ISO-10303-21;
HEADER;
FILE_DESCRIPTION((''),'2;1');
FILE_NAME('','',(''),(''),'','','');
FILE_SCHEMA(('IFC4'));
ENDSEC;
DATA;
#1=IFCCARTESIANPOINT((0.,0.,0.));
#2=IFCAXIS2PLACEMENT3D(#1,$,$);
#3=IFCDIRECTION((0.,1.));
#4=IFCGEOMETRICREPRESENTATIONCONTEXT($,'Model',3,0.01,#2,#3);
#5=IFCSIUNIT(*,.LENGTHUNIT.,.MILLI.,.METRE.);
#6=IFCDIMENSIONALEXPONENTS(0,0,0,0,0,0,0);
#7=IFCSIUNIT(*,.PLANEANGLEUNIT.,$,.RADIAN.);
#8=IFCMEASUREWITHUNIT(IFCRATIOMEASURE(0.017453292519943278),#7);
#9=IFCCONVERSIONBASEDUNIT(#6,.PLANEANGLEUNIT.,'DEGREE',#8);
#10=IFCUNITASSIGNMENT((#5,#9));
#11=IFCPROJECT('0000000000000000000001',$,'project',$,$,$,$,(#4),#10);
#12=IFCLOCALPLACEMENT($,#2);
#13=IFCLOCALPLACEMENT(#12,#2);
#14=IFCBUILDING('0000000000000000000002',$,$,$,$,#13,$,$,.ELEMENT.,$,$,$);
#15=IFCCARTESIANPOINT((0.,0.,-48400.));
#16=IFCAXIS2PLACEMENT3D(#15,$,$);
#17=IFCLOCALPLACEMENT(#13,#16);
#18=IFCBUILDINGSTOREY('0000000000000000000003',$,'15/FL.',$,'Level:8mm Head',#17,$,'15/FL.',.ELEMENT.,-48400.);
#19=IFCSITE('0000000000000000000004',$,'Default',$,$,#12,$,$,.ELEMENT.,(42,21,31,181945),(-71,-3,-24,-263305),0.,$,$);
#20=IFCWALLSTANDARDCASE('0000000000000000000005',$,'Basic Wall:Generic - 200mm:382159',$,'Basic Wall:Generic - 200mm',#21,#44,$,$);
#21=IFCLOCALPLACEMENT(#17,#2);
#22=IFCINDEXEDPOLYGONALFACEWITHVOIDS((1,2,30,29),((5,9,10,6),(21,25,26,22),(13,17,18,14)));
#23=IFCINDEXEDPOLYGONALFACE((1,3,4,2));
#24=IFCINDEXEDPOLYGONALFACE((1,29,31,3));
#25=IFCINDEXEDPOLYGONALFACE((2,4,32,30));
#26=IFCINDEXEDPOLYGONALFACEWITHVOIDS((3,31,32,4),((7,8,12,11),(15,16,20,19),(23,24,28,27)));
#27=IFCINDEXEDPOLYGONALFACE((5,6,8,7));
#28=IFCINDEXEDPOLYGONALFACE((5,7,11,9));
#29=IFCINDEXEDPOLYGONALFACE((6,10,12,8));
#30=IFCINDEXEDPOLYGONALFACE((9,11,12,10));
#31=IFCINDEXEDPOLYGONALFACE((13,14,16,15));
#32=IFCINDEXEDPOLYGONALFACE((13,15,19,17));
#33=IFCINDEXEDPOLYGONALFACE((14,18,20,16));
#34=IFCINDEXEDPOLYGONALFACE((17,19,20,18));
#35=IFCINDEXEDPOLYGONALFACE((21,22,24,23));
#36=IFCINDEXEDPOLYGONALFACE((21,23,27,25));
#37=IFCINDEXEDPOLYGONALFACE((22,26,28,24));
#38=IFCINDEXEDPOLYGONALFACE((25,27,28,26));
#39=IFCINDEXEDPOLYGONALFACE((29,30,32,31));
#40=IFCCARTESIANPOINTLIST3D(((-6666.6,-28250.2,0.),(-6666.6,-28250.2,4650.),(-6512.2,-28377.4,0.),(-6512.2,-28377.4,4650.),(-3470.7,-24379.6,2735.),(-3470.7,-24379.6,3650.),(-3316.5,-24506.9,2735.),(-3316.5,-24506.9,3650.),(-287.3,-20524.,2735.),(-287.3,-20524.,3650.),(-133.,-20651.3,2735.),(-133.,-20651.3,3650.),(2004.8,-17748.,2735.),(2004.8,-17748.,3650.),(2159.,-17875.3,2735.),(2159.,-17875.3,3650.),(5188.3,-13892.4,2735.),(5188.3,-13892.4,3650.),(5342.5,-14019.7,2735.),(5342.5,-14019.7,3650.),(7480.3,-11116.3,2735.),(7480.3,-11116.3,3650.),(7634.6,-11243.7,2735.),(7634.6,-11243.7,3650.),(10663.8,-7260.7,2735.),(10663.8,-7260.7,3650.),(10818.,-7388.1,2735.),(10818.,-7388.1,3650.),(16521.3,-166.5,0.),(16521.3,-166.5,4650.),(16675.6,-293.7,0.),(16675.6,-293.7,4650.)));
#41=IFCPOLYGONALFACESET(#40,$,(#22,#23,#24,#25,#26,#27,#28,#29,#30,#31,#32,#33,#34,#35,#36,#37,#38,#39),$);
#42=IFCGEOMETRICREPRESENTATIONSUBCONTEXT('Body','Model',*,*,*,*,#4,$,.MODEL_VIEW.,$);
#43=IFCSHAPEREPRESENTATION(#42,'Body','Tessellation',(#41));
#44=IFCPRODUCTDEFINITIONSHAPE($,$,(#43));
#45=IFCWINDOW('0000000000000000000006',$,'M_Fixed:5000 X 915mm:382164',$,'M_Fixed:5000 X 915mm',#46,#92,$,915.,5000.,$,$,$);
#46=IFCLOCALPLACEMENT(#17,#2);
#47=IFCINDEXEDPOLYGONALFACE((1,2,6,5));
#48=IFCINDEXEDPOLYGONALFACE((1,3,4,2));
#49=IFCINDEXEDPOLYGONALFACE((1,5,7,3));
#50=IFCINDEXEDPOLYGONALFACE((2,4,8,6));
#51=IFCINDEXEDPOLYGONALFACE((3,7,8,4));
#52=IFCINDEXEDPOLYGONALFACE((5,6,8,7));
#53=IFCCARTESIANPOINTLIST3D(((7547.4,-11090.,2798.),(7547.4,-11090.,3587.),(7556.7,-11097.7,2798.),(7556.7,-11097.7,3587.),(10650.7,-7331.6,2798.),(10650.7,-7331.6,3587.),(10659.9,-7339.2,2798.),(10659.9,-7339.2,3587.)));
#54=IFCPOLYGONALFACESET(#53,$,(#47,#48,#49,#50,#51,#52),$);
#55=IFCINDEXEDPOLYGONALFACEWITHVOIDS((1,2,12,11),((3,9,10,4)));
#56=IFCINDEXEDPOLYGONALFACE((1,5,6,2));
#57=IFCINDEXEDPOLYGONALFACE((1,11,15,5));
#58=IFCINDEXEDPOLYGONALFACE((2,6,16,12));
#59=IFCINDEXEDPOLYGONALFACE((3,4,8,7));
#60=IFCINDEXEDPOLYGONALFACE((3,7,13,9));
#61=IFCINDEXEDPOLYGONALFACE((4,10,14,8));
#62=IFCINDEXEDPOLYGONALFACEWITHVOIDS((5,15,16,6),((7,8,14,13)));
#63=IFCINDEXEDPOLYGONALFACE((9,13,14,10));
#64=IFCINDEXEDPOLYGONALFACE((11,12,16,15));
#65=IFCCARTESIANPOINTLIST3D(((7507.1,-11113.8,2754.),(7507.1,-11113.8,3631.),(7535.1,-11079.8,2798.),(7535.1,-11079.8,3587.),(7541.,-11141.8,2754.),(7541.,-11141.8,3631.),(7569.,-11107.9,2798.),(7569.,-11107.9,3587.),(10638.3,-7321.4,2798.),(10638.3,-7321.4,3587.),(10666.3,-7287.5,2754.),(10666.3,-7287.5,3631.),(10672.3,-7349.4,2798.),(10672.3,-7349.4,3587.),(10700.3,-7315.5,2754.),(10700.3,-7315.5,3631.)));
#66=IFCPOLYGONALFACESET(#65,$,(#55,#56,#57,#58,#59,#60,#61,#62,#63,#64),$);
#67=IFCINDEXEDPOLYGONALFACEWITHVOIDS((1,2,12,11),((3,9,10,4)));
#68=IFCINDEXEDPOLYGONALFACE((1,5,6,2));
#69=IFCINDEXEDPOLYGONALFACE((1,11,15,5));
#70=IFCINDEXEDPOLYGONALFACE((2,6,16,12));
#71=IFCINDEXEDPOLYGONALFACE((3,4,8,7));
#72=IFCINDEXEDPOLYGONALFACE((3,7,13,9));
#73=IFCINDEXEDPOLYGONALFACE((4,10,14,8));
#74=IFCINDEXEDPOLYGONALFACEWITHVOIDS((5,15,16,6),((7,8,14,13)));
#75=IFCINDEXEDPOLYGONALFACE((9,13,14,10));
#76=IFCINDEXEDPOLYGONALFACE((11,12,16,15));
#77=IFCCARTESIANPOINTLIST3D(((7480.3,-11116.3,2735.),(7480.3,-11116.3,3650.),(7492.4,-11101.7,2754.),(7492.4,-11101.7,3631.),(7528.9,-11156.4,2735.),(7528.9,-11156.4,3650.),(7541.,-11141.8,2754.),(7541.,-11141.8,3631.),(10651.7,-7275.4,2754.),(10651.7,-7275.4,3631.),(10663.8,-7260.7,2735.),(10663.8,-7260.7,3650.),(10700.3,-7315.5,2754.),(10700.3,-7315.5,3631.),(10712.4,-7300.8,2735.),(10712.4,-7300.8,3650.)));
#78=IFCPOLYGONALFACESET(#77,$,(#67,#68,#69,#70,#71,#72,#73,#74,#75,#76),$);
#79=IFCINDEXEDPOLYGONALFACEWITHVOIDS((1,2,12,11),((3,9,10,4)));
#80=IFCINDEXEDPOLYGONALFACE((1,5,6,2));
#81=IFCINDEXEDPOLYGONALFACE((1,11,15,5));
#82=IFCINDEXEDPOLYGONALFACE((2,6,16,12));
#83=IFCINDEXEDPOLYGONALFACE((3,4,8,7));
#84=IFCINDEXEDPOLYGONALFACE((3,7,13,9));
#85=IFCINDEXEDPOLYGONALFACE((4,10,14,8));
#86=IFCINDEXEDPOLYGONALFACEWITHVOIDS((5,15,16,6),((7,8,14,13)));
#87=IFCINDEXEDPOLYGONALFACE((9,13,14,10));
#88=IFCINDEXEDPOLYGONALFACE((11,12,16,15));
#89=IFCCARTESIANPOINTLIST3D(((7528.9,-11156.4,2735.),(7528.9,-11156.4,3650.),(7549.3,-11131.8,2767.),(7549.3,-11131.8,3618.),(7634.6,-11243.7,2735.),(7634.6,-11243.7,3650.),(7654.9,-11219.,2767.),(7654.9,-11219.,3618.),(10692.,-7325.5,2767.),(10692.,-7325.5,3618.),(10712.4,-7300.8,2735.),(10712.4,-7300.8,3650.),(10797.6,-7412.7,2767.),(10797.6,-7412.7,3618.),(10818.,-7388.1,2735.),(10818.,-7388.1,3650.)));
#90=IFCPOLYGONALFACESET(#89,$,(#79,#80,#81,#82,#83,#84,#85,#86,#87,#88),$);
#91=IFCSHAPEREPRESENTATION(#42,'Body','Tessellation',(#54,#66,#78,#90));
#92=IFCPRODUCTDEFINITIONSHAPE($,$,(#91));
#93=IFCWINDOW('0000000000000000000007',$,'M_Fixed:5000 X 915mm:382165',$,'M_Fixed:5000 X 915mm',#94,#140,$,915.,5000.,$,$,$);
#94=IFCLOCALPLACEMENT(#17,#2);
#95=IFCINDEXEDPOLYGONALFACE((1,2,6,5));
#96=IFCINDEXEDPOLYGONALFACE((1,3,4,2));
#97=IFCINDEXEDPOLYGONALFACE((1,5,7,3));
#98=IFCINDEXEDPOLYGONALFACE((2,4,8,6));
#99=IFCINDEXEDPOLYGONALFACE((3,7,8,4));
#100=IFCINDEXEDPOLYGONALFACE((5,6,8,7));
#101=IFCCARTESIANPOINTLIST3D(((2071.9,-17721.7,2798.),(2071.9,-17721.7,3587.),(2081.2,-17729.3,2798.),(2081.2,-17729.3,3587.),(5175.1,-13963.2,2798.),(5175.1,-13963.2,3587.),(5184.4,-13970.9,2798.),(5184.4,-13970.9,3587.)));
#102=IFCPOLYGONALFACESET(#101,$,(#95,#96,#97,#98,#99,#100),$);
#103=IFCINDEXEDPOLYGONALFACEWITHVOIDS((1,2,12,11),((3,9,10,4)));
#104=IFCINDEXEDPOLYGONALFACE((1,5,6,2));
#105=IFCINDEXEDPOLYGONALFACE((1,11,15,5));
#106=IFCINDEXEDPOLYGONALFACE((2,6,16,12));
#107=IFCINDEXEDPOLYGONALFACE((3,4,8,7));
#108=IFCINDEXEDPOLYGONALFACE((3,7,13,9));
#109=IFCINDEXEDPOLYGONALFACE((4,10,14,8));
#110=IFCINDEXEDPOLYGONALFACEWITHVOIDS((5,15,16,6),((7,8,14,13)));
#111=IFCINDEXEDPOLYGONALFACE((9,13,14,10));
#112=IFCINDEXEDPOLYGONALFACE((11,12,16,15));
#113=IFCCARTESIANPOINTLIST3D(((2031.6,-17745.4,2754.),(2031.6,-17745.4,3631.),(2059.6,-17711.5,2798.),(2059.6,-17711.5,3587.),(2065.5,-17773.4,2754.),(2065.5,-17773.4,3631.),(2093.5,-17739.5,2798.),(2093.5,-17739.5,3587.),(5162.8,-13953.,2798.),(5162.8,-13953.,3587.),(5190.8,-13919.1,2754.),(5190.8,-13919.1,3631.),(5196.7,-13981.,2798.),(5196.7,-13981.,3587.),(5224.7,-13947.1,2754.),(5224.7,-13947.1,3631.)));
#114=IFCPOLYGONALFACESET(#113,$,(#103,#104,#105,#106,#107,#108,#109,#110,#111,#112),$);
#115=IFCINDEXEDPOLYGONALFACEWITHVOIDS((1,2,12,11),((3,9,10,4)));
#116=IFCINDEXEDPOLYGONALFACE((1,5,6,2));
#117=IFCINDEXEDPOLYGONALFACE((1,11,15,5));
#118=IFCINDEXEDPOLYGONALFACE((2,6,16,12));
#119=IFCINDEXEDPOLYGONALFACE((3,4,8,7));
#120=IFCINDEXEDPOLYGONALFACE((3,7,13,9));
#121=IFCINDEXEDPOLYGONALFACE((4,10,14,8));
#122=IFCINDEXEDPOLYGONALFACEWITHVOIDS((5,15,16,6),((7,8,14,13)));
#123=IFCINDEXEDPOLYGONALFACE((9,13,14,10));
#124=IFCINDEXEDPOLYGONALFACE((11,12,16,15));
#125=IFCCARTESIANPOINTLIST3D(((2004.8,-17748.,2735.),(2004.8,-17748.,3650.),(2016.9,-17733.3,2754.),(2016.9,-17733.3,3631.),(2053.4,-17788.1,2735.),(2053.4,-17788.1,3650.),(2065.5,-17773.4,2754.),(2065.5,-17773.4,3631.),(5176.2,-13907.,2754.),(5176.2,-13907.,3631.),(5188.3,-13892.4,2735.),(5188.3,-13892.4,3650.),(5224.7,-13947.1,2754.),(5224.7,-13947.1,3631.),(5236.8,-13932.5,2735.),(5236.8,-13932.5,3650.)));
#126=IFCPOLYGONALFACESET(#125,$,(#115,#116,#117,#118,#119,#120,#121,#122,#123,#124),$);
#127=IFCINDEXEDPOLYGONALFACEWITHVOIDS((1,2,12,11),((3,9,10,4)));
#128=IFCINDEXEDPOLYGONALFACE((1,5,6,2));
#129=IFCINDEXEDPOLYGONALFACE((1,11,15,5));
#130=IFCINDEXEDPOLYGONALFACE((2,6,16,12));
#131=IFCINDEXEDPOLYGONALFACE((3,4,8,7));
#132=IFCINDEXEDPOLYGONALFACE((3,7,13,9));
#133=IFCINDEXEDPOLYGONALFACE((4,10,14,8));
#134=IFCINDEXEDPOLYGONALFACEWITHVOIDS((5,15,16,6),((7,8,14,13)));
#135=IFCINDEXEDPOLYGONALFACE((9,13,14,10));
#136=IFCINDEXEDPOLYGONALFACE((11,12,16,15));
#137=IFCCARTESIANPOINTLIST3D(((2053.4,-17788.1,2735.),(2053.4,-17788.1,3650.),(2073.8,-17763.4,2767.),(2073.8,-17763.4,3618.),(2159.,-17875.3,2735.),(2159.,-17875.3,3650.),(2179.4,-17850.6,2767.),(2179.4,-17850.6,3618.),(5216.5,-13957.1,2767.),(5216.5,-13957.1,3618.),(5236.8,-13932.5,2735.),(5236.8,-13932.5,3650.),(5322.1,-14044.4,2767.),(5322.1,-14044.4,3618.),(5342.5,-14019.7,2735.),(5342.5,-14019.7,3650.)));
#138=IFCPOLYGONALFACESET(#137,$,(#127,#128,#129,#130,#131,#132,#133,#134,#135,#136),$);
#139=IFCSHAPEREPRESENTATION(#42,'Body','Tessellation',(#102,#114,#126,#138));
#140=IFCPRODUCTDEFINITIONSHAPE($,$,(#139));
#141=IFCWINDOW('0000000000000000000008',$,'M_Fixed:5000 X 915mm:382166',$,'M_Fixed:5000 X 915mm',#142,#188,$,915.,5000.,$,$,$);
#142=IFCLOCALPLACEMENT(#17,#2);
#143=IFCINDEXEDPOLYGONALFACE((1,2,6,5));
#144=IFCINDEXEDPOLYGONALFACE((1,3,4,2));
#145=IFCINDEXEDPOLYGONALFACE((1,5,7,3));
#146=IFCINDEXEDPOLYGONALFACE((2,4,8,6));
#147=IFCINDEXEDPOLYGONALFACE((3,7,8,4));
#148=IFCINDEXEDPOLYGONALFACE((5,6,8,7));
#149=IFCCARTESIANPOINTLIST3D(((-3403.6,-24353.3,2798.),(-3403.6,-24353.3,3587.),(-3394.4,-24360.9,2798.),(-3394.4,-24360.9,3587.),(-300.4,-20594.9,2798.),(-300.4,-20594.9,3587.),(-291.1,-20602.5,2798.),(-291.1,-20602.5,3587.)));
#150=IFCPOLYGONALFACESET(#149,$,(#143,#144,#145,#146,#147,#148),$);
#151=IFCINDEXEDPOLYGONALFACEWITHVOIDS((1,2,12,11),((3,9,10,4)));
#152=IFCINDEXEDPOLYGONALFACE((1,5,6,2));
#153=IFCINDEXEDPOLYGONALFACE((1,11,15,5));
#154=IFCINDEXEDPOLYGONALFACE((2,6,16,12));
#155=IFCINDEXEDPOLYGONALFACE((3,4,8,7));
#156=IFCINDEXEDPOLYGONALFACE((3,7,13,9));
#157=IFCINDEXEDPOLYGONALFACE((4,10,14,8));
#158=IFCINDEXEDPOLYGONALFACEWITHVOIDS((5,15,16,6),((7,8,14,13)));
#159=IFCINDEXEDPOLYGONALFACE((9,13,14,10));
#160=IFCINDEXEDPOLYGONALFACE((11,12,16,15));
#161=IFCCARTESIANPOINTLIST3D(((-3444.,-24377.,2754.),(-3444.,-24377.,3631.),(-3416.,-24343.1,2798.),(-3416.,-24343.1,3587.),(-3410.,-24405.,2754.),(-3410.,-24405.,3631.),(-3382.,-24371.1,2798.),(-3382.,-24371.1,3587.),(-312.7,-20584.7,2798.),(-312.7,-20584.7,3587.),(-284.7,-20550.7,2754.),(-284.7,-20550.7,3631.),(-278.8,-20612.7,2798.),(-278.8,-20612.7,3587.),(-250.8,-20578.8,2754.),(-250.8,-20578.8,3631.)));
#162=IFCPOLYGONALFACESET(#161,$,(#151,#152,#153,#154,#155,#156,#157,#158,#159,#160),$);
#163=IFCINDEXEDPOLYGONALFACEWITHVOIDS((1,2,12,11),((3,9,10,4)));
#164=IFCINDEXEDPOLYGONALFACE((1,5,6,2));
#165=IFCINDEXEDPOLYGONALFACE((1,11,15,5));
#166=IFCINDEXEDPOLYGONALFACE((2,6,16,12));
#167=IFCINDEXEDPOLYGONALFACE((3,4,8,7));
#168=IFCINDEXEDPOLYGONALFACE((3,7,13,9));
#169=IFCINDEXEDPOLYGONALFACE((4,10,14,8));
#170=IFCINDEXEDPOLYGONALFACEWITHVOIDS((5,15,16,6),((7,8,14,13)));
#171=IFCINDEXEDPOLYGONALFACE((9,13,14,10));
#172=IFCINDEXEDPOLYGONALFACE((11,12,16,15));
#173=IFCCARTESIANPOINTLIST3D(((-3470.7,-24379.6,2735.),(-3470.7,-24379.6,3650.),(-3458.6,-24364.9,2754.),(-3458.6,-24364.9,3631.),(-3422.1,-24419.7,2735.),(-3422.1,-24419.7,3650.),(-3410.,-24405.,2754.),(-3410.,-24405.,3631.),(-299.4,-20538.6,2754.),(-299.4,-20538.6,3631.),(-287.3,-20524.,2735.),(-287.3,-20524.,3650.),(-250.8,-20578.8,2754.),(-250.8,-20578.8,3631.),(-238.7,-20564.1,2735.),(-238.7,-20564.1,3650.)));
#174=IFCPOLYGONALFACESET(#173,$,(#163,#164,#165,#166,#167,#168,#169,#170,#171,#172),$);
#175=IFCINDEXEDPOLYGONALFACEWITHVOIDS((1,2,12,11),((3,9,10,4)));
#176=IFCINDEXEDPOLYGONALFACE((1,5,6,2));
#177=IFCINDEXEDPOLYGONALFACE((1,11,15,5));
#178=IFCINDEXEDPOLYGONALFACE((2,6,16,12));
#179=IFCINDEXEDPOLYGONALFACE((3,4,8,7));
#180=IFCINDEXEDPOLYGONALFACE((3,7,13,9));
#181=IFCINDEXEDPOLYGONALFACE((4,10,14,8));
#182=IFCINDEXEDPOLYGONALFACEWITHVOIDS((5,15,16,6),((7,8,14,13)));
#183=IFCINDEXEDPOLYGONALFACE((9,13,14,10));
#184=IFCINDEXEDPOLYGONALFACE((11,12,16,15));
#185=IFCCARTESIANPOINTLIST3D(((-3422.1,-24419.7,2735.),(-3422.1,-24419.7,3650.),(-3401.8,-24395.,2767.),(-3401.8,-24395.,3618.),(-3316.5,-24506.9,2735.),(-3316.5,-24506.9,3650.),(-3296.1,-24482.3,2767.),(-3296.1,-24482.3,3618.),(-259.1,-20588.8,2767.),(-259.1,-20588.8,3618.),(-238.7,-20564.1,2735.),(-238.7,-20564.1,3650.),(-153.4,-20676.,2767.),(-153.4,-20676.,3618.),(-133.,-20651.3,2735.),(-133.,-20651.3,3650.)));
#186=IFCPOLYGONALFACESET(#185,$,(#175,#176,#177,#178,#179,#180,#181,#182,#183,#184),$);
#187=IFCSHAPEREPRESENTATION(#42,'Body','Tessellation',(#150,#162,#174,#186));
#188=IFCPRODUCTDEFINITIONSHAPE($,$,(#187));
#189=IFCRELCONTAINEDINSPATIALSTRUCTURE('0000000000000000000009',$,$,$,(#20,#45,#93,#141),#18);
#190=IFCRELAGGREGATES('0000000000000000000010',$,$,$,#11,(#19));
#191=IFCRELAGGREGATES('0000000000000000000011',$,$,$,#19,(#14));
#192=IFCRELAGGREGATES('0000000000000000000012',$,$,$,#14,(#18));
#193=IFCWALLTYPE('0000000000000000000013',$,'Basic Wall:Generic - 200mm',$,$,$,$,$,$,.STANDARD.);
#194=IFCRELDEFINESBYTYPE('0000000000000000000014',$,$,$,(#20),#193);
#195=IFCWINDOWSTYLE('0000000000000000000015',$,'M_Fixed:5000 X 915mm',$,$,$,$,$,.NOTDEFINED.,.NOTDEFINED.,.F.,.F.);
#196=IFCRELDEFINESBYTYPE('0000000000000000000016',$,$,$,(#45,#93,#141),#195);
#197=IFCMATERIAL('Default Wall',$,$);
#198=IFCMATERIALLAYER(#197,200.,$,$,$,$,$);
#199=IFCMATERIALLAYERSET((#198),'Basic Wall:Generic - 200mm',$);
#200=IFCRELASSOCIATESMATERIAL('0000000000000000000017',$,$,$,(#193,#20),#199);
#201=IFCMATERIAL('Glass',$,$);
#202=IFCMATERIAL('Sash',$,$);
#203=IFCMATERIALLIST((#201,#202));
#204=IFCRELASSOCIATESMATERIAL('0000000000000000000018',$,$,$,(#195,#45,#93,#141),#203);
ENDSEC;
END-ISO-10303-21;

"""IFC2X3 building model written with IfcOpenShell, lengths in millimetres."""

from ifc_helpers import new_model, entity, si_unit, converted_unit, direction, frame, frame_2d, origin, place, context, subcontext, project, spatial, polyline, rectangle, outline, extrude, source, transform, mapped, material, material_list, layer, layer_set, layer_usage, type_object, type_shapes, element, fill, save


model = new_model("IFC2X3")

# Units and contexts
model_context = context("Model", 3, precision=0.01, world=origin(), true_north=direction((0.0, 1.0)))
body_context = subcontext(model_context, "Body", "Model", "MODEL_VIEW")
ifc_project = project(units=[si_unit("LENGTHUNIT", "METRE", prefix="MILLI"), converted_unit("PLANEANGLEUNIT", "DEGREE", entity("IfcRatioMeasure", 0.017453292519943278), si_unit("PLANEANGLEUNIT", "RADIAN"), dimensions=[0, 0, 0, 0, 0, 0, 0])], contexts=[model_context])

# Site, building, storey
site_placement = place(None, origin())
site = spatial("IfcSite", under=ifc_project, at=site_placement, Name="Default", CompositionType="ELEMENT", RefLatitude=(42, 21, 31, 181945), RefLongitude=(-71, -3, -24, -263305), RefElevation=0.0)
building_placement = place(site_placement, origin())
building = spatial("IfcBuilding", under=site, at=building_placement, CompositionType="ELEMENT")
storey_placement = place(building_placement, frame((0.0, 0.0, -48400.0)))
storey = spatial("IfcBuildingStorey", under=building, at=storey_placement, Name="15/FL.", ObjectType="Level:8mm Head", LongName="15/FL.", CompositionType="ELEMENT", Elevation=-48400.0)

# Shared definitions
ifc_material_1 = material(Name="Default Wall")
ifc_layer = layer(ifc_material_1, 200.0)
ifc_layer_set = layer_set([ifc_layer], Name="Basic Wall:Generic - 200mm")
ifc_layer_usage = layer_usage(ifc_layer_set, "AXIS2", "NEGATIVE", 100.0)
wall_type = type_object("IfcWallType", Name="Basic Wall:Generic - 200mm", PredefinedType="STANDARD", material=ifc_layer_set)

# Wall, openings, windows
wall_1_placement = place(storey_placement, frame((17107.9, 386.9, 0.0), z_axis=(0.0, 0.0, 1.0), x_axis=(-0.63669, -0.77112, 0.0)))
wall_1 = element("IfcWallStandardCase", 1, at=wall_1_placement, inside=storey, type_object=wall_type, material=ifc_layer_usage, Name="Basic Wall:Generic - 200mm:382159", ObjectType="Basic Wall:Generic - 200mm", context=body_context, shape_type="SweptSolid", body=[
    extrude(outline(polyline([(37219.6, -100.0), (37219.4, 100.0), (37019.4, 100.0), (800.0, 100.0), (800.3, -100.0), (37219.6, -100.0)])), origin(), (0.0, 0.0, 1.0), 4650.0),
])
opening_1_placement = place(wall_1_placement, origin())
element("IfcOpeningElement", 2, at=opening_1_placement, cuts=wall_1, ObjectType="Opening", context=body_context, shape_type="SweptSolid", body=[
    extrude(rectangle(XDim=1000.0, YDim=1012.7, at=frame_2d((0.0, 0.0), x_axis=(1.0, 0.0))), frame((294.0, -182.9, 500.0), z_axis=(-0.001252, 0.999999, 0.0), x_axis=(0.0, 0.0, -1.0)), (0.0, 0.0, 1.0), 1010.1),
])
opening_2_placement = place(wall_1_placement, frame((15000.1, 100.0, 2735.0)))
opening_2 = element("IfcOpeningElement", 3, at=opening_2_placement, cuts=wall_1, ObjectType="Opening", context=body_context, shape_type="SweptSolid", body=[
    extrude(rectangle(XDim=915.0, YDim=5000.0, at=frame_2d((457.5, 2500.0), x_axis=(1.0, 0.0))), frame((0.0, 0.0, 0.0), z_axis=(0.0, -1.0, 0.0), x_axis=(0.0, 0.0, 1.0)), (0.0, 0.0, 1.0), 200.0),
])
opening_3_placement = place(wall_1_placement, frame((23600.1, 100.0, 2735.0)))
opening_3 = element("IfcOpeningElement", 4, at=opening_3_placement, cuts=wall_1, ObjectType="Opening", context=body_context, shape_type="SweptSolid", body=[
    extrude(rectangle(XDim=915.0, YDim=5000.0, at=frame_2d((457.5, 2500.0), x_axis=(1.0, 0.0))), frame((0.0, 0.0, 0.0), z_axis=(0.0, -1.0, 0.0), x_axis=(0.0, 0.0, 1.0)), (0.0, 0.0, 1.0), 200.0),
])
opening_4_placement = place(wall_1_placement, frame((32200.1, 100.0, 2735.0)))
opening_4 = element("IfcOpeningElement", 5, at=opening_4_placement, cuts=wall_1, ObjectType="Opening", context=body_context, shape_type="SweptSolid", body=[
    extrude(rectangle(XDim=915.0, YDim=5000.0, at=frame_2d((457.5, 2500.0), x_axis=(1.0, 0.0))), frame((0.0, 0.0, 0.0), z_axis=(0.0, -1.0, 0.0), x_axis=(0.0, 0.0, 1.0)), (0.0, 0.0, 1.0), 200.0),
])
ifc_material_2 = material(Name="Glass")
ifc_material_3 = material(Name="Sash")
ifc_material_list = material_list([ifc_material_2, ifc_material_3])
window_style_1 = type_object("IfcWindowStyle", Name="M_Fixed:5000 X 915mm", ConstructionType="NOTDEFINED", OperationType="NOTDEFINED", ParameterTakesPrecedence=False, Sizeable=False, material=ifc_material_list)
shared_shape_1 = source(origin(), body_context, "Body", "SweptSolid", [
    extrude(rectangle(XDim=12.0, YDim=4874.0, at=frame_2d((0.0, 0.0), x_axis=(1.0, 0.0))), frame((2500.0, 159.0, 63.0), z_axis=(0.0, 0.0, 1.0), x_axis=(0.0, -1.0, 0.0)), (0.0, 0.0, 1.0), 789.0),
    extrude(outline(polyline([(-2481.0, -438.5), (2481.0, -438.5), (2481.0, 438.5), (-2481.0, 438.5), (-2481.0, -438.5)]), holes=[polyline([(-2437.0, -394.5), (-2437.0, 394.5), (2437.0, 394.5), (2437.0, -394.5), (-2437.0, -394.5)])]), frame((2500.0, 137.0, 457.5), z_axis=(0.0, 1.0, 0.0), x_axis=(1.0, 0.0, 0.0)), (0.0, 0.0, 1.0), 44.0),
    extrude(outline(polyline([(-2500.0, -457.5), (2500.0, -457.5), (2500.0, 457.5), (-2500.0, 457.5), (-2500.0, -457.5)]), holes=[polyline([(-2481.0, -438.5), (-2481.0, 438.5), (2481.0, 438.5), (2481.0, -438.5), (-2481.0, -438.5)])]), frame((2500.0, 137.0, 457.5), z_axis=(0.0, 1.0, 0.0), x_axis=(1.0, 0.0, 0.0)), (0.0, 0.0, 1.0), 63.0),
    extrude(outline(polyline([(-2500.0, -457.5), (2500.0, -457.5), (2500.0, 457.5), (-2500.0, 457.5), (-2500.0, -457.5)]), holes=[polyline([(-2468.0, -425.5), (-2468.0, 425.5), (2468.0, 425.5), (2468.0, -425.5), (-2468.0, -425.5)])]), frame((2500.0, 0.0, 457.5), z_axis=(0.0, 1.0, 0.0), x_axis=(1.0, 0.0, 0.0)), (0.0, 0.0, 1.0), 137.0),
])
type_shapes(window_style_1, [shared_shape_1])
window_1_placement = place(opening_2_placement, frame((0.0, 0.0, 0.0), z_axis=(0.0, 0.0, 1.0), x_axis=(-1.0, 0.0, 0.0)))
window_1 = element("IfcWindow", 6, at=window_1_placement, inside=storey, type_object=window_style_1, material=ifc_material_list, Name="M_Fixed:5000 X 915mm:382164", ObjectType="M_Fixed:5000 X 915mm", OverallHeight=915.0, OverallWidth=5000.0, context=body_context, shape_type="MappedRepresentation", body=[
    mapped(shared_shape_1, transform((0.0, 0.0, 0.0), scale=1.0)),
])
fill(opening_2, window_1)
window_2_placement = place(opening_3_placement, frame((0.0, 0.0, 0.0), z_axis=(0.0, 0.0, 1.0), x_axis=(-1.0, 0.0, 0.0)))
window_2 = element("IfcWindow", 7, at=window_2_placement, inside=storey, type_object=window_style_1, material=ifc_material_list, Name="M_Fixed:5000 X 915mm:382165", ObjectType="M_Fixed:5000 X 915mm", OverallHeight=915.0, OverallWidth=5000.0, context=body_context, shape_type="MappedRepresentation", body=[
    mapped(shared_shape_1, transform((0.0, 0.0, 0.0), scale=1.0)),
])
fill(opening_3, window_2)
window_3_placement = place(opening_4_placement, frame((0.0, 0.0, 0.0), z_axis=(0.0, 0.0, 1.0), x_axis=(-1.0, 0.0, 0.0)))
window_3 = element("IfcWindow", 8, at=window_3_placement, inside=storey, type_object=window_style_1, material=ifc_material_list, Name="M_Fixed:5000 X 915mm:382166", ObjectType="M_Fixed:5000 X 915mm", OverallHeight=915.0, OverallWidth=5000.0, context=body_context, shape_type="MappedRepresentation", body=[
    mapped(shared_shape_1, transform((0.0, 0.0, 0.0), scale=1.0)),
])
fill(opening_4, window_3)

save(model, "model.ifc")
